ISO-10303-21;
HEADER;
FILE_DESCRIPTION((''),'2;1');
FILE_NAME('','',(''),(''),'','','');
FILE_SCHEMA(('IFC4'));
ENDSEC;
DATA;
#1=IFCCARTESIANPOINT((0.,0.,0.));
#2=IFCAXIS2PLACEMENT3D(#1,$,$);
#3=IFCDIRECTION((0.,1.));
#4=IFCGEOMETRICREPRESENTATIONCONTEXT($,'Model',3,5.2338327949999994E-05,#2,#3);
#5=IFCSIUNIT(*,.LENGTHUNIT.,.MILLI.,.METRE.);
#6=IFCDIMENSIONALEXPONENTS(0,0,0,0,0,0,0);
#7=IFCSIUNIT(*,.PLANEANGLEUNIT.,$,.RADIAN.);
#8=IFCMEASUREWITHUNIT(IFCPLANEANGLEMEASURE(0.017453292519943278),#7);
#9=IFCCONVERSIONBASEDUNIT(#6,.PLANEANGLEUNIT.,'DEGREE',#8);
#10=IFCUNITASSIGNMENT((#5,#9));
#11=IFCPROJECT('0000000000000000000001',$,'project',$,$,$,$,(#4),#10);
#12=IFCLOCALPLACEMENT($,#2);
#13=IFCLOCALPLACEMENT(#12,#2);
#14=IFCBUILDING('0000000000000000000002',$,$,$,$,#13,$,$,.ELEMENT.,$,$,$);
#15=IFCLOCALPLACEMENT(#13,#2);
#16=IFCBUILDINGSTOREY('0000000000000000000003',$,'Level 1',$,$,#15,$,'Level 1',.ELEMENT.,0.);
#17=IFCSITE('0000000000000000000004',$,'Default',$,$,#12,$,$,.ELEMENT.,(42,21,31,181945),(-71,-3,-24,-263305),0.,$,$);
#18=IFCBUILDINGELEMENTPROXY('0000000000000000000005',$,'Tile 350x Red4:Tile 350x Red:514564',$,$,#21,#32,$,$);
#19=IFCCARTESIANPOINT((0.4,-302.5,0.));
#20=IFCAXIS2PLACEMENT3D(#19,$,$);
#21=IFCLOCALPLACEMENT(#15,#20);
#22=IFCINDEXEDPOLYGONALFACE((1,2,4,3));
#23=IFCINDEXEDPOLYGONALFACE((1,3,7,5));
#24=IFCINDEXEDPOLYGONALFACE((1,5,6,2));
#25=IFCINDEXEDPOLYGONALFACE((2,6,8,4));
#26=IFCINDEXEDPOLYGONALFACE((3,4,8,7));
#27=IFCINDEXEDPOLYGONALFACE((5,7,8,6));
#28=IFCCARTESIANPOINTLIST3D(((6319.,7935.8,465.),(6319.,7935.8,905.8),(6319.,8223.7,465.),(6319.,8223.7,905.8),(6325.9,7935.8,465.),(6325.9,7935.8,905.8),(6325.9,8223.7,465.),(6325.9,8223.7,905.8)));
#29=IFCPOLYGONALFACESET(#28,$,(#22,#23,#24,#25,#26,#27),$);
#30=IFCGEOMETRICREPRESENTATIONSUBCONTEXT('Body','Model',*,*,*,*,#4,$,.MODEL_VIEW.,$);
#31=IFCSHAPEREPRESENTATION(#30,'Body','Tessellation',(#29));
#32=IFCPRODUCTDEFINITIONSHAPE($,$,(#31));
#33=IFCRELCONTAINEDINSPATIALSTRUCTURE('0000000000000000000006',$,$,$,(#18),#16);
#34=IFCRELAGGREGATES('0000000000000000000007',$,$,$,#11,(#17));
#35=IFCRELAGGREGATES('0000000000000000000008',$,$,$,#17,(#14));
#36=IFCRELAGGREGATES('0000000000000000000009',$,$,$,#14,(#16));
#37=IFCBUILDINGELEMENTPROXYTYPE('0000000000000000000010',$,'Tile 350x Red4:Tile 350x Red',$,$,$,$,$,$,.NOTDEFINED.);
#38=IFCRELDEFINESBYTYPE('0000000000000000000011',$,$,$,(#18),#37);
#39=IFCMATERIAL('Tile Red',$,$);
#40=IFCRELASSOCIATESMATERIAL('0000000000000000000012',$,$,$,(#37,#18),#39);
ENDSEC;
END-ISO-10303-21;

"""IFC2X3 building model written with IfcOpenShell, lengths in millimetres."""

from ifc_helpers import new_model, entity, si_unit, converted_unit, direction, frame, frame_2d, origin, place, context, subcontext, project, spatial, rectangle, extrude, source, transform, mapped, material, type_object, type_shapes, element, save


model = new_model("IFC2X3")

# Units and contexts
model_context = context("Model", 3, precision=5.2338327949999994e-05, world=origin(), true_north=direction((0.0, 1.0)))
body_context = subcontext(model_context, "Body", "Model", "MODEL_VIEW")
ifc_project = project(units=[si_unit("LENGTHUNIT", "METRE", prefix="MILLI"), converted_unit("PLANEANGLEUNIT", "DEGREE", entity("IfcPlaneAngleMeasure", 0.017453292519943278), si_unit("PLANEANGLEUNIT", "RADIAN"), dimensions=[0, 0, 0, 0, 0, 0, 0])], contexts=[model_context])

# Site, building, storey
site_placement = place(None, origin())
site = spatial("IfcSite", under=ifc_project, at=site_placement, Name="Default", CompositionType="ELEMENT", RefLatitude=(42, 21, 31, 181945), RefLongitude=(-71, -3, -24, -263305), RefElevation=0.0)
building_placement = place(site_placement, origin())
building = spatial("IfcBuilding", under=site, at=building_placement, CompositionType="ELEMENT")
storey_placement = place(building_placement, origin())
storey = spatial("IfcBuildingStorey", under=building, at=storey_placement, Name="Level 1", LongName="Level 1", CompositionType="ELEMENT", Elevation=0.0)

# Building element proxy
ifc_material_1 = material(Name="Tile Red")
building_element_proxy_type_1 = type_object("IfcBuildingElementProxyType", Name="Tile 350x Red4:Tile 350x Red", PredefinedType="NOTDEFINED", material=ifc_material_1)
shared_shape_1 = source(origin(), body_context, "Body", "SweptSolid", [
    extrude(rectangle(XDim=6.9, YDim=287.9, at=frame_2d((0.0, 0.0), x_axis=(1.0, 0.0))), frame((6322.4, 8079.7, 465.0)), (0.0, 0.0, 1.0), 440.8),
])
type_shapes(building_element_proxy_type_1, [shared_shape_1])
proxy_1_placement = place(storey_placement, frame((0.4, -302.5, 0.0)))
element("IfcBuildingElementProxy", 1, at=proxy_1_placement, inside=storey, type_object=building_element_proxy_type_1, material=ifc_material_1, Name="Tile 350x Red4:Tile 350x Red:514564", context=body_context, shape_type="MappedRepresentation", body=[
    mapped(shared_shape_1, transform((0.0, 0.0, 0.0), scale=1.0)),
])

save(model, "model.ifc")
